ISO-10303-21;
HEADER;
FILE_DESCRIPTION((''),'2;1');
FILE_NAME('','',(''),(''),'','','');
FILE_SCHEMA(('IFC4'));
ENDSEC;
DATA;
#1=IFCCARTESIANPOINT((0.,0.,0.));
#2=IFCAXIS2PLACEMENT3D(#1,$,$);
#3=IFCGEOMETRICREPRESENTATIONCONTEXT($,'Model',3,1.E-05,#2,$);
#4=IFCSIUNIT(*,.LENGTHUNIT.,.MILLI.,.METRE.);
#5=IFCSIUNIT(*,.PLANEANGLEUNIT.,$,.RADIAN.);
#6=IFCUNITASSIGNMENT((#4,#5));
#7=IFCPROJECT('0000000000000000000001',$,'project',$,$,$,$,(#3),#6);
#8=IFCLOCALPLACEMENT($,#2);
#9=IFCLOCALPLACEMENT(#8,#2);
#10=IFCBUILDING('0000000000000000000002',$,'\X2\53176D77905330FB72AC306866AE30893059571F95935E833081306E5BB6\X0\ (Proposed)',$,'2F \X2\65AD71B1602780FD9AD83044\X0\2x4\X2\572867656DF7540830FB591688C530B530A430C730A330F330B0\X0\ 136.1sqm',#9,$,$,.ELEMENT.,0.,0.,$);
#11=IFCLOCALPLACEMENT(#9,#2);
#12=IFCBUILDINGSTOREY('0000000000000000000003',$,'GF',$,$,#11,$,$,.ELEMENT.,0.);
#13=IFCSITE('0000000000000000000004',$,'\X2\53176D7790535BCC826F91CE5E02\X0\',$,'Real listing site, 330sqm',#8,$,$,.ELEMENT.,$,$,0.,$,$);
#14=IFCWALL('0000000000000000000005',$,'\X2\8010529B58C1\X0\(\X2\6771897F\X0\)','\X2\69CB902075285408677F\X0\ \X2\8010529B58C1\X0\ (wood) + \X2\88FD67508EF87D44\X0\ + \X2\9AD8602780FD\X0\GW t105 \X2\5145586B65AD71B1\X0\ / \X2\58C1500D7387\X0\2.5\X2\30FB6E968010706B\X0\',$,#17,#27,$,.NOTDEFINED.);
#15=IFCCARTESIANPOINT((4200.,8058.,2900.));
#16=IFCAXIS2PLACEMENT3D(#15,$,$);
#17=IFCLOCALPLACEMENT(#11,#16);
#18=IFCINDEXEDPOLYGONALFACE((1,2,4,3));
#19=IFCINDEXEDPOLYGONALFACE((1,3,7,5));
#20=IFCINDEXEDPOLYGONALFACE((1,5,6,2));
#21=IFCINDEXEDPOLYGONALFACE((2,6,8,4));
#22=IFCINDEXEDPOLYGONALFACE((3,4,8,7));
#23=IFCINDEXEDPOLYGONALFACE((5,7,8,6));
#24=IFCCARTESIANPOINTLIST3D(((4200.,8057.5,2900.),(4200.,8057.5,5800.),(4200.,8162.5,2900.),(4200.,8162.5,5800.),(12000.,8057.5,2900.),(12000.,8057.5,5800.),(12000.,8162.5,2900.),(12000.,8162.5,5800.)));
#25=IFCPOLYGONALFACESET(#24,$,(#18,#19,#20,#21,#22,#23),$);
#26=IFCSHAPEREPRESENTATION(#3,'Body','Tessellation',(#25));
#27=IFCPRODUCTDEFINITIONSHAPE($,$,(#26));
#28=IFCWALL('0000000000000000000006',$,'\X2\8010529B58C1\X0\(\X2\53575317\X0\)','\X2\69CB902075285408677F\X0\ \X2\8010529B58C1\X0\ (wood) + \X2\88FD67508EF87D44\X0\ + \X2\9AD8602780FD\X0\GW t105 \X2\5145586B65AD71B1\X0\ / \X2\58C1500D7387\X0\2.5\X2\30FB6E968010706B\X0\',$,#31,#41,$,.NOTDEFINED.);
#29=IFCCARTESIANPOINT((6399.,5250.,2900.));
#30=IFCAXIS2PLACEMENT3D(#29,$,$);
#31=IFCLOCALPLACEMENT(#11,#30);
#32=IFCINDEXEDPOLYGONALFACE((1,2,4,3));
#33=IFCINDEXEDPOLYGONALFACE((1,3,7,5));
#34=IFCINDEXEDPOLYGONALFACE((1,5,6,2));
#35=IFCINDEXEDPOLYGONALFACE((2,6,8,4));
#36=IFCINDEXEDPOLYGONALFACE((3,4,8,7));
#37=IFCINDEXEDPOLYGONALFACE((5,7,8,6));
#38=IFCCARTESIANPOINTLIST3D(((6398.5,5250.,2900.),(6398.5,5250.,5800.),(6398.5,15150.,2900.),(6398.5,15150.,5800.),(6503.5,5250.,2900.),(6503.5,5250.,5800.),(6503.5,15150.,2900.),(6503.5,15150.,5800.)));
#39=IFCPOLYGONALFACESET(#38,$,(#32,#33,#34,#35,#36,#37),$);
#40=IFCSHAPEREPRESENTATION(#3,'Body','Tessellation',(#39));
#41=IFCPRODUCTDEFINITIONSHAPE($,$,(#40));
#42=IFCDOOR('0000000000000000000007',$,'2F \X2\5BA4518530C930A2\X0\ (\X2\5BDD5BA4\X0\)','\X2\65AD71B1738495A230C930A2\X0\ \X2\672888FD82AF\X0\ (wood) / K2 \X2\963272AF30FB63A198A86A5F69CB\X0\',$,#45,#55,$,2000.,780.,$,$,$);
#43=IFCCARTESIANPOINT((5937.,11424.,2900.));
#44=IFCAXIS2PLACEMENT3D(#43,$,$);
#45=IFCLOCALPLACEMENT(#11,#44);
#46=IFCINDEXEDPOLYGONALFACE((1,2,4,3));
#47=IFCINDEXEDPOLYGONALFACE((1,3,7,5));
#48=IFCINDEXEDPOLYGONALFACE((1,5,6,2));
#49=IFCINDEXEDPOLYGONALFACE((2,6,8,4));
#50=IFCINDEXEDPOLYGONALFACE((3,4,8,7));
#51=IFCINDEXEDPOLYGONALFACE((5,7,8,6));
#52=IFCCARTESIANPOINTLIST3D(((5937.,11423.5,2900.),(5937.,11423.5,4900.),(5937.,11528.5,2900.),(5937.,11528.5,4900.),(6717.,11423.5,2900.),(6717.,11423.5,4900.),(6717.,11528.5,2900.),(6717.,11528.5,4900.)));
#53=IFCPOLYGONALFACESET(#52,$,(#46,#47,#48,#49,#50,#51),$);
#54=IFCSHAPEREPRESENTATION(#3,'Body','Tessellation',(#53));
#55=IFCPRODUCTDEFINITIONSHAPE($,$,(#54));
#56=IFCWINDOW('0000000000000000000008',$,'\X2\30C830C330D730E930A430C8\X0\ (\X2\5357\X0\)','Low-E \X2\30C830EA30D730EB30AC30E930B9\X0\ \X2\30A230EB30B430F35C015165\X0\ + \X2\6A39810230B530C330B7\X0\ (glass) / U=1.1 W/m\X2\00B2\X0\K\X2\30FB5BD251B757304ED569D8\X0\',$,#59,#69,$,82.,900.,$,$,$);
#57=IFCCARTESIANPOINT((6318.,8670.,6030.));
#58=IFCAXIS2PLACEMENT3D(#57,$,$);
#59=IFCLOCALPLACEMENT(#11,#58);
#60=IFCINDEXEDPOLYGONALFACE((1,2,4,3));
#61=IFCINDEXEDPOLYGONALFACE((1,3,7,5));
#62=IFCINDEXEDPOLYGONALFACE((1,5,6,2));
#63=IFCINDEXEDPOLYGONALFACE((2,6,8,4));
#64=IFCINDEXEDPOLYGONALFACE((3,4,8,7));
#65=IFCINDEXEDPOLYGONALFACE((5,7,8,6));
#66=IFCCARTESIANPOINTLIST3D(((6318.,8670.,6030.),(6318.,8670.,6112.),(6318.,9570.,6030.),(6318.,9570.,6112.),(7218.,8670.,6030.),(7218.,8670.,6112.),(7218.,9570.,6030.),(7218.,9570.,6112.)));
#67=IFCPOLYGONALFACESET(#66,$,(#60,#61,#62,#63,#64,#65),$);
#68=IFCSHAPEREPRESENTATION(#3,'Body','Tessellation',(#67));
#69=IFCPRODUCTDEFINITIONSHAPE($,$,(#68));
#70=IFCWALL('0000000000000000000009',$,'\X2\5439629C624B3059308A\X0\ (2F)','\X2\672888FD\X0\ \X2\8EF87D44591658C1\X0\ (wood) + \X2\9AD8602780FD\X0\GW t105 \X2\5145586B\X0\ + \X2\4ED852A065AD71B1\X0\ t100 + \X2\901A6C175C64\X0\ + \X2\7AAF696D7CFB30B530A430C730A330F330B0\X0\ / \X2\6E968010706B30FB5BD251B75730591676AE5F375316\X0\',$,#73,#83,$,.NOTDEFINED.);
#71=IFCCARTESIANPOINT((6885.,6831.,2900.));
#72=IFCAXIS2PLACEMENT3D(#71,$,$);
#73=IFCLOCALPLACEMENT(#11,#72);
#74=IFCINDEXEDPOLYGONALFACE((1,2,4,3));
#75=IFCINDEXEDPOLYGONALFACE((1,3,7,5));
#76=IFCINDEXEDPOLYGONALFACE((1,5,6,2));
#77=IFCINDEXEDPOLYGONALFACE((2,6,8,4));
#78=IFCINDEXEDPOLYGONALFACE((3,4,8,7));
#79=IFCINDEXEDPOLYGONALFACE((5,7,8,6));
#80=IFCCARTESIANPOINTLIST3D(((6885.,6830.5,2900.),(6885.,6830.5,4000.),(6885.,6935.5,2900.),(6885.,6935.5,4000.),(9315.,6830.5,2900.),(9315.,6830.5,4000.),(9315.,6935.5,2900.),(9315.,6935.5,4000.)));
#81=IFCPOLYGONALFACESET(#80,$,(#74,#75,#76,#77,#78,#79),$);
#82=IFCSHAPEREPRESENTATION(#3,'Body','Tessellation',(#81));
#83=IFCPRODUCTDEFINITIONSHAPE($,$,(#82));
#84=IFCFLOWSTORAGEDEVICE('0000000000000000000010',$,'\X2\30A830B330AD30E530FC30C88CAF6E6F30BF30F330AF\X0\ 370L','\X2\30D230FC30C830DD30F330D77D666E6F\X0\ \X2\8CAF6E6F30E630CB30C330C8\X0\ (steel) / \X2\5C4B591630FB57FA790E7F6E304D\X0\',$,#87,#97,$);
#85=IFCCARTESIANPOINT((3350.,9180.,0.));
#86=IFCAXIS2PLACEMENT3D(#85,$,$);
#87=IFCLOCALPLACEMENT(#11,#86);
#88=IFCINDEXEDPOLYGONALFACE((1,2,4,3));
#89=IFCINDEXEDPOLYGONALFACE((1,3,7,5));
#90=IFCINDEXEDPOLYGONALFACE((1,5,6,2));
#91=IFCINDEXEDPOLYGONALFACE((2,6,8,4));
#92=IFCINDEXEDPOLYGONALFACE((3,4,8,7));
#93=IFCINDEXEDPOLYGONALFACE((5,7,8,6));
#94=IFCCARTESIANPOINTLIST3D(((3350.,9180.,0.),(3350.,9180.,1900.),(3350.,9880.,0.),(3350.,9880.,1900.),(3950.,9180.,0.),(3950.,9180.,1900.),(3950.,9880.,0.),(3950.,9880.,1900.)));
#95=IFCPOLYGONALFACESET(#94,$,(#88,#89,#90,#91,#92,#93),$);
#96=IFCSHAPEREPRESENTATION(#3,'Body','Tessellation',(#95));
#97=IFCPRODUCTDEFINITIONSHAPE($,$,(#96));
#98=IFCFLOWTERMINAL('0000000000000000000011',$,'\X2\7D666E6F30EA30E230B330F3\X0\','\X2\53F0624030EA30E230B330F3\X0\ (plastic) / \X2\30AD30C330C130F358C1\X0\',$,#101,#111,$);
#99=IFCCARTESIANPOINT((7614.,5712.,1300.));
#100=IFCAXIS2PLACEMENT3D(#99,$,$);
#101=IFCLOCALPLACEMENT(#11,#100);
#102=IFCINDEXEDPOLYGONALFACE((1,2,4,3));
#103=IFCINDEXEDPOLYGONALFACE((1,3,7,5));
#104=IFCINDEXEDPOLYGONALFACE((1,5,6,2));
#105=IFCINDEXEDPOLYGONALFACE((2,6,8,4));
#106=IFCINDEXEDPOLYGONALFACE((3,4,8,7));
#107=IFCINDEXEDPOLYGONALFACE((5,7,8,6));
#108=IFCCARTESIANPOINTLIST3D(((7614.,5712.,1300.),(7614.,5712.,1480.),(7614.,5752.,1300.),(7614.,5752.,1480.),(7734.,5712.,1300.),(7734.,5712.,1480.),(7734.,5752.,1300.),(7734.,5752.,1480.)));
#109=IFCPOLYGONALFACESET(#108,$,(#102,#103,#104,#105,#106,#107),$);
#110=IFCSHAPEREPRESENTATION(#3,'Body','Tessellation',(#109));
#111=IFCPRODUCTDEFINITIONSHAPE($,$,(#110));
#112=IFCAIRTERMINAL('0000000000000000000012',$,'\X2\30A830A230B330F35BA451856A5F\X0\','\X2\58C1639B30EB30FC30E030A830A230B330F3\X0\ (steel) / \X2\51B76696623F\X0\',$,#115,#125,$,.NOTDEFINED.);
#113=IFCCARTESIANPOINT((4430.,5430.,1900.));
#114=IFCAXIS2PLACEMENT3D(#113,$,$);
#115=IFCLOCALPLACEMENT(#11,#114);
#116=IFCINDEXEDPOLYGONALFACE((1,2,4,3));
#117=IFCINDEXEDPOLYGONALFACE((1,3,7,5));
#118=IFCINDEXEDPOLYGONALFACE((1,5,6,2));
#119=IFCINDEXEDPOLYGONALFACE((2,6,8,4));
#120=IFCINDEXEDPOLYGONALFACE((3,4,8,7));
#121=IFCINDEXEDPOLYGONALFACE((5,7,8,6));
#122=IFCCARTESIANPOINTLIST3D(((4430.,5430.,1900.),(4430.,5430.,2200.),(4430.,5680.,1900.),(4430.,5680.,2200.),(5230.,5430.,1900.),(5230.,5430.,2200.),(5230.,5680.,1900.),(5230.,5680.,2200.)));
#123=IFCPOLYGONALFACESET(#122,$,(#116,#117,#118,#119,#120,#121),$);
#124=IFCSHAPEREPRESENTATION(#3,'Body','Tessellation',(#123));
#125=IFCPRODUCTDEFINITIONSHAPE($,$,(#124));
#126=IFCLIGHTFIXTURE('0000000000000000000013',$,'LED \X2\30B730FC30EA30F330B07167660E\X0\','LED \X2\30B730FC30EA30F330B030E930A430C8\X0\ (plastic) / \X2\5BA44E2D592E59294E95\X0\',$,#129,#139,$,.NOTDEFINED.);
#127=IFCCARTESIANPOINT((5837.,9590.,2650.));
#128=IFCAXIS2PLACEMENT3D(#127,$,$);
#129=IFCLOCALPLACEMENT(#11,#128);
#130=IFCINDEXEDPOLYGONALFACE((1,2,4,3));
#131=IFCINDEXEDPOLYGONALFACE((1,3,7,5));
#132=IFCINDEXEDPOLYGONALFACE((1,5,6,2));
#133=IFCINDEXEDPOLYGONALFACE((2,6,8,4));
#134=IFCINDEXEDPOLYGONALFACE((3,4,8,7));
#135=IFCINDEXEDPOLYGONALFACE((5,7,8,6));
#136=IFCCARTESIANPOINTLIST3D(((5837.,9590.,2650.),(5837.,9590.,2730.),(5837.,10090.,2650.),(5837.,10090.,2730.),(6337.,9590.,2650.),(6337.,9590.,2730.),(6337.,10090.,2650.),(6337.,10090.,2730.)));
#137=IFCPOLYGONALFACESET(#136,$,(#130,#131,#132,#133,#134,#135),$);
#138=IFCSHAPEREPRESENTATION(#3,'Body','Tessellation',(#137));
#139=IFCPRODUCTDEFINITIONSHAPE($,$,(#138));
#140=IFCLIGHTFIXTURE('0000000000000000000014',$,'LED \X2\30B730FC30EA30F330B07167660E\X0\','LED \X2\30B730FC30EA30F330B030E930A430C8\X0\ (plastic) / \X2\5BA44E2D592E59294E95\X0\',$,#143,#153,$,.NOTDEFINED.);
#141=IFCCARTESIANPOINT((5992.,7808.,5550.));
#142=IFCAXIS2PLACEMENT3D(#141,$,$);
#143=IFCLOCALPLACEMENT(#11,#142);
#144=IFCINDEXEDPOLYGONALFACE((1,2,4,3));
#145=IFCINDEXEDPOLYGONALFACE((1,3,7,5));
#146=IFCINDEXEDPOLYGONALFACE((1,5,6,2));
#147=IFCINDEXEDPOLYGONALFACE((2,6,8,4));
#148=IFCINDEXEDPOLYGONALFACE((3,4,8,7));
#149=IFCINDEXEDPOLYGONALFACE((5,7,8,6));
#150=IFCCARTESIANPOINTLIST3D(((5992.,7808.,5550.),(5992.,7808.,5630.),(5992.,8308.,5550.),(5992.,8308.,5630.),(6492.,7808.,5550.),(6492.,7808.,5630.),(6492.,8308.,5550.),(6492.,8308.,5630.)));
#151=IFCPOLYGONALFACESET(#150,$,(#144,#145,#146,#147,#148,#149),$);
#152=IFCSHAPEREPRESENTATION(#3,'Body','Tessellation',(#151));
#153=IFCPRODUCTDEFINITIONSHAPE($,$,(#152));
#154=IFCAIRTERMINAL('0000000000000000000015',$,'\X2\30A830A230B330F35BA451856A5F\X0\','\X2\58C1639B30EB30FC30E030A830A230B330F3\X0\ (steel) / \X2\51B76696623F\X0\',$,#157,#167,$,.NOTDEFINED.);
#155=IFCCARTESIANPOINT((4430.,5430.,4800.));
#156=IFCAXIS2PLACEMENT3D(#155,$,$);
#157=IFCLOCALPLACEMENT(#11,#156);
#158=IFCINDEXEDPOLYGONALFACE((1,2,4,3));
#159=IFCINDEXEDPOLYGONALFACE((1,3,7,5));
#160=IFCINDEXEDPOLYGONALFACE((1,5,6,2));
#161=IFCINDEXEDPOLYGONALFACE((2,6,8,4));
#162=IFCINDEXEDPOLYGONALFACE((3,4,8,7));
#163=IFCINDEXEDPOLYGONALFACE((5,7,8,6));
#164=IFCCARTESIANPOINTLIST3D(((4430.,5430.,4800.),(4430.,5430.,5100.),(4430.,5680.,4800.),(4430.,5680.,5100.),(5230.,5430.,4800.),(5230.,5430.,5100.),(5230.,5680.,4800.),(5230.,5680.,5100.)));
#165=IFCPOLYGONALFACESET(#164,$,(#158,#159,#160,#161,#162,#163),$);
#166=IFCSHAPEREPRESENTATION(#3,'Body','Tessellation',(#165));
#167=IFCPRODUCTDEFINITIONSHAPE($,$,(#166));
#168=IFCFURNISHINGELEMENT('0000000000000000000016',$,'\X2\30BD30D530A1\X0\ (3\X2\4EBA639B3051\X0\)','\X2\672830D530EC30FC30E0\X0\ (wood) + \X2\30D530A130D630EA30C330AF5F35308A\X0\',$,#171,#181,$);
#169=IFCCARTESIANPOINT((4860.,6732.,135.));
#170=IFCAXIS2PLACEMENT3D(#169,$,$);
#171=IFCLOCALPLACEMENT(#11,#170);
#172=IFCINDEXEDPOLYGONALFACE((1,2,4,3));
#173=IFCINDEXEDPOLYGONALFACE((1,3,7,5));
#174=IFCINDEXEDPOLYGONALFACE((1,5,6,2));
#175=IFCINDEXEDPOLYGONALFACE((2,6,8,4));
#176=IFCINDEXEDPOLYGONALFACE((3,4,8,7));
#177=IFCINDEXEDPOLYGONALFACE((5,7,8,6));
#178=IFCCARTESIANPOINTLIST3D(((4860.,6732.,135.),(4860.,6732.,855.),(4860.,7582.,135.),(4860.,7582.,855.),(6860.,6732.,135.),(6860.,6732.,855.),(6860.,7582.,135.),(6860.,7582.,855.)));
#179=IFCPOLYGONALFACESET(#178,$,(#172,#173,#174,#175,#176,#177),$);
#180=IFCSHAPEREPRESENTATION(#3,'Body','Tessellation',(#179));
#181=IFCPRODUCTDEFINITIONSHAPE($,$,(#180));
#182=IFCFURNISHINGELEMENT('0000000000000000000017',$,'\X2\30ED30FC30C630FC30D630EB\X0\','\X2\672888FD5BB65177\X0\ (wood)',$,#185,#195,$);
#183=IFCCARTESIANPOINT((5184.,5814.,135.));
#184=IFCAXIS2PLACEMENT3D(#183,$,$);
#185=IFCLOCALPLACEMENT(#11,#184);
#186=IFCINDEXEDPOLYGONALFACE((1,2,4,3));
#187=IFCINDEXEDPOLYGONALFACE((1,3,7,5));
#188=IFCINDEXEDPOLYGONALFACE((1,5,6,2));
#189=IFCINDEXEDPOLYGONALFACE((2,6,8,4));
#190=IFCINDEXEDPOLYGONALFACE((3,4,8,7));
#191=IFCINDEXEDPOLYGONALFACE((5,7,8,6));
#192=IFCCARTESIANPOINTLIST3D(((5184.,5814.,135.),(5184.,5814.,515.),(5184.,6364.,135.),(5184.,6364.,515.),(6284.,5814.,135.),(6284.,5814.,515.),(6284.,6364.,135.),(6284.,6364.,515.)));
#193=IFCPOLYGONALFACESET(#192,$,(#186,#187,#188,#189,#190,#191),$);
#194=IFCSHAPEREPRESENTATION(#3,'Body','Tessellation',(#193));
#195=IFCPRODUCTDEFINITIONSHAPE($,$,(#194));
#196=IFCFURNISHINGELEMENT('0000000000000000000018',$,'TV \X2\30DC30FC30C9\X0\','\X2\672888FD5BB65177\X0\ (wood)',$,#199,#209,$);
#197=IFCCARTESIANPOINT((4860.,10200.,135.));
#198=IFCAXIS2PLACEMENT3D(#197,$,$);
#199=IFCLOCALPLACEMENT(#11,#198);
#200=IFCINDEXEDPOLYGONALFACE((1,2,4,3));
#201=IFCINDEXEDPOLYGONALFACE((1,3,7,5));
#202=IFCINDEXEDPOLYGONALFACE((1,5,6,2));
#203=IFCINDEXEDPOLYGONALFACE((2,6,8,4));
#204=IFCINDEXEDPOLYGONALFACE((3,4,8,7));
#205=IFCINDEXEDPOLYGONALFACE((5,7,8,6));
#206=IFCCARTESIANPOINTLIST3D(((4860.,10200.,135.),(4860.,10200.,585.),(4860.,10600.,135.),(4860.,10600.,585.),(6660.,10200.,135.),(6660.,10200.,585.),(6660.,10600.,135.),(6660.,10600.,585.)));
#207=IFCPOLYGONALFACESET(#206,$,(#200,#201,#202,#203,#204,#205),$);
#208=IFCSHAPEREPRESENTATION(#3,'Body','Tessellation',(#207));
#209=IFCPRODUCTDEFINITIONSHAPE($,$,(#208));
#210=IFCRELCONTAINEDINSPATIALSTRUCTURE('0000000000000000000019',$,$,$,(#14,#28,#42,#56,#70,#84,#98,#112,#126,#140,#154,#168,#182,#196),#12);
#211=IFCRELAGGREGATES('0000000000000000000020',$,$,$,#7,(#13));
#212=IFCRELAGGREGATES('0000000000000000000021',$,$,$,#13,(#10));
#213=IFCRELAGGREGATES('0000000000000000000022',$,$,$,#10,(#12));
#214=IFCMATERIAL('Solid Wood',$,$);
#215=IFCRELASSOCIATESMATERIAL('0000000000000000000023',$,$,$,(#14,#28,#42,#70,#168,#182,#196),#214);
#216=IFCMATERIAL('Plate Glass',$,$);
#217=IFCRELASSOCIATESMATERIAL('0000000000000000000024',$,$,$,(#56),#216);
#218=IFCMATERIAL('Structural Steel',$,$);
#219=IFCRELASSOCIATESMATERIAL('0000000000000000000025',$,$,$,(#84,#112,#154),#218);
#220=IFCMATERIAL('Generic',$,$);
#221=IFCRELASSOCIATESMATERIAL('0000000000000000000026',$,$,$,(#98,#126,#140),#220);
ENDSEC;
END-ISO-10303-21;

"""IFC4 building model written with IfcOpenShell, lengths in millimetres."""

from ifc_helpers import new_model, si_unit, frame, frame_2d, origin, place, context, project, spatial, rectangle, extrude, material, element, fill, save


model = new_model("IFC4")

# Units and contexts
model_context = context("Model", 3, precision=1e-05, world=origin())
ifc_project = project(units=[si_unit("LENGTHUNIT", "METRE", prefix="MILLI"), si_unit("PLANEANGLEUNIT", "RADIAN")], contexts=[model_context])

# Site, building, storey
site_placement = place(None, origin())
site = spatial("IfcSite", under=ifc_project, at=site_placement, Name="北海道富良野市", ObjectType="Real listing site, 330sqm", CompositionType="ELEMENT", RefElevation=0.0)
building_placement = place(site_placement, origin())
building = spatial("IfcBuilding", under=site, at=building_placement, Name="北海道・犬と暮らす土間広めの家 (Proposed)", ObjectType="2F 断熱性能高い2x4在来混合・外装サイディング 136.1sqm", CompositionType="ELEMENT", ElevationOfRefHeight=0.0, ElevationOfTerrain=0.0)
storey_placement = place(building_placement, origin())
storey = spatial("IfcBuildingStorey", under=building, at=storey_placement, Name="GF", CompositionType="ELEMENT", Elevation=0.0)

# Shared definitions
ifc_material_1 = material(Name="Solid Wood")

# Wall
wall_1_placement = place(storey_placement, frame((4200.0, 8058.0, 2900.0)))
element("IfcWall", 1, at=wall_1_placement, inside=storey, material=ifc_material_1, Name="耐力壁(東西)", Description="構造用合板 耐力壁 (wood) + 製材軸組 + 高性能GW t105 充填断熱 / 壁倍率2.5・準耐火", PredefinedType="NOTDEFINED", context=model_context, shape_type="SweptSolid", body=[
    extrude(rectangle(XDim=7800.0, YDim=105.0, at=frame_2d((3900.0, 52.0))), frame((4200.0, 8058.0, 2900.0)), (0.0, 0.0, 1.0), 2900.0),
])

# Wall, opening, door
wall_2_placement = place(storey_placement, frame((6399.0, 5250.0, 2900.0)))
wall_2 = element("IfcWall", 2, at=wall_2_placement, inside=storey, material=ifc_material_1, Name="耐力壁(南北)", Description="構造用合板 耐力壁 (wood) + 製材軸組 + 高性能GW t105 充填断熱 / 壁倍率2.5・準耐火", PredefinedType="NOTDEFINED", context=model_context, shape_type="SweptSolid", body=[
    extrude(rectangle(XDim=105.0, YDim=9900.0, at=frame_2d((52.0, 4950.0))), frame((6399.0, 5250.0, 2900.0)), (0.0, 0.0, 1.0), 2900.0),
])
opening_placement = place(storey_placement, frame((5937.0, 11424.0, 2900.0)))
opening = element("IfcOpeningElement", 3, at=opening_placement, cuts=wall_2, PredefinedType="NOTDEFINED", context=model_context, shape_type="SweptSolid", body=[
    extrude(rectangle(XDim=780.0, YDim=105.0, at=frame_2d((390.0, 52.0))), frame((5937.0, 11424.0, 2900.0)), (0.0, 0.0, 1.0), 2000.0),
])
door_placement = place(storey_placement, frame((5937.0, 11424.0, 2900.0)))
door = element("IfcDoor", 4, at=door_placement, inside=storey, material=ifc_material_1, Name="2F 室内ドア (寝室)", Description="断熱玄関ドア 木製芯 (wood) / K2 防犯・採風機構", OverallHeight=2000.0, OverallWidth=780.0, context=model_context, shape_type="SweptSolid", body=[
    extrude(rectangle(XDim=780.0, YDim=105.0, at=frame_2d((390.0, 52.0))), frame((5937.0, 11424.0, 2900.0)), (0.0, 0.0, 1.0), 2000.0),
])
fill(opening, door)

# Window
ifc_material_2 = material(Name="Plate Glass")
window_placement = place(storey_placement, frame((6318.0, 8670.0, 6030.0)))
element("IfcWindow", 5, at=window_placement, inside=storey, material=ifc_material_2, Name="トップライト (南)", Description="Low-E トリプルガラス アルゴン封入 + 樹脂サッシ (glass) / U=1.1 W/m²K・寒冷地仕様", OverallHeight=82.0, OverallWidth=900.0, context=model_context, shape_type="SweptSolid", body=[
    extrude(rectangle(XDim=900.0, YDim=900.0, at=frame_2d((450.0, 450.0))), frame((6318.0, 8670.0, 6030.0)), (0.0, 0.0, 1.0), 82.0),
])

# Wall
wall_3_placement = place(storey_placement, frame((6885.0, 6831.0, 2900.0)))
element("IfcWall", 6, at=wall_3_placement, inside=storey, material=ifc_material_1, Name="吹抜手すり (2F)", Description="木製 軸組外壁 (wood) + 高性能GW t105 充填 + 付加断熱 t100 + 通気層 + 窯業系サイディング / 準耐火・寒冷地外皮強化", PredefinedType="NOTDEFINED", context=model_context, shape_type="SweptSolid", body=[
    extrude(rectangle(XDim=2430.0, YDim=105.0, at=frame_2d((1215.0, 52.0))), frame((6885.0, 6831.0, 2900.0)), (0.0, 0.0, 1.0), 1100.0),
])

# Flow storage device
ifc_material_3 = material(Name="Structural Steel")
flow_storage_device_placement = place(storey_placement, frame((3350.0, 9180.0, 0.0)))
element("IfcFlowStorageDevice", 7, at=flow_storage_device_placement, inside=storey, material=ifc_material_3, Name="エコキュート貯湯タンク 370L", Description="ヒートポンプ給湯 貯湯ユニット (steel) / 屋外・基礎置き", context=model_context, shape_type="SweptSolid", body=[
    extrude(rectangle(XDim=600.0, YDim=700.0, at=frame_2d((300.0, 350.0))), frame((3350.0, 9180.0, 0.0)), (0.0, 0.0, 1.0), 1900.0),
])

# Flow terminal
ifc_material_4 = material(Name="Generic")
flow_terminal_placement = place(storey_placement, frame((7614.0, 5712.0, 1300.0)))
element("IfcFlowTerminal", 8, at=flow_terminal_placement, inside=storey, material=ifc_material_4, Name="給湯リモコン", Description="台所リモコン (plastic) / キッチン壁", context=model_context, shape_type="SweptSolid", body=[
    extrude(rectangle(XDim=120.0, YDim=40.0, at=frame_2d((60.0, 20.0))), frame((7614.0, 5712.0, 1300.0)), (0.0, 0.0, 1.0), 180.0),
])

# Air terminal
air_terminal_1_placement = place(storey_placement, frame((4430.0, 5430.0, 1900.0)))
element("IfcAirTerminal", 9, at=air_terminal_1_placement, inside=storey, material=ifc_material_3, Name="エアコン室内機", Description="壁掛ルームエアコン (steel) / 冷暖房", PredefinedType="NOTDEFINED", context=model_context, shape_type="SweptSolid", body=[
    extrude(rectangle(XDim=800.0, YDim=250.0, at=frame_2d((400.0, 125.0))), frame((4430.0, 5430.0, 1900.0)), (0.0, 0.0, 1.0), 300.0),
])

# Light fixtures
light_fixture_1_placement = place(storey_placement, frame((5837.0, 9590.0, 2650.0)))
element("IfcLightFixture", 10, at=light_fixture_1_placement, inside=storey, material=ifc_material_4, Name="LED シーリング照明", Description="LED シーリングライト (plastic) / 室中央天井", PredefinedType="NOTDEFINED", context=model_context, shape_type="SweptSolid", body=[
    extrude(rectangle(XDim=500.0, YDim=500.0, at=frame_2d((250.0, 250.0))), frame((5837.0, 9590.0, 2650.0)), (0.0, 0.0, 1.0), 80.0),
])
light_fixture_2_placement = place(storey_placement, frame((5992.0, 7808.0, 5550.0)))
element("IfcLightFixture", 11, at=light_fixture_2_placement, inside=storey, material=ifc_material_4, Name="LED シーリング照明", Description="LED シーリングライト (plastic) / 室中央天井", PredefinedType="NOTDEFINED", context=model_context, shape_type="SweptSolid", body=[
    extrude(rectangle(XDim=500.0, YDim=500.0, at=frame_2d((250.0, 250.0))), frame((5992.0, 7808.0, 5550.0)), (0.0, 0.0, 1.0), 80.0),
])

# Air terminal
air_terminal_2_placement = place(storey_placement, frame((4430.0, 5430.0, 4800.0)))
element("IfcAirTerminal", 12, at=air_terminal_2_placement, inside=storey, material=ifc_material_3, Name="エアコン室内機", Description="壁掛ルームエアコン (steel) / 冷暖房", PredefinedType="NOTDEFINED", context=model_context, shape_type="SweptSolid", body=[
    extrude(rectangle(XDim=800.0, YDim=250.0, at=frame_2d((400.0, 125.0))), frame((4430.0, 5430.0, 4800.0)), (0.0, 0.0, 1.0), 300.0),
])

# Furnishing elements
furnishing_1_placement = place(storey_placement, frame((4860.0, 6732.0, 135.0)))
element("IfcFurnishingElement", 13, at=furnishing_1_placement, inside=storey, material=ifc_material_1, Name="ソファ (3人掛け)", Description="木フレーム (wood) + ファブリック張り", context=model_context, shape_type="SweptSolid", body=[
    extrude(rectangle(XDim=2000.0, YDim=850.0, at=frame_2d((1000.0, 425.0))), frame((4860.0, 6732.0, 135.0)), (0.0, 0.0, 1.0), 720.0),
])
furnishing_2_placement = place(storey_placement, frame((5184.0, 5814.0, 135.0)))
element("IfcFurnishingElement", 14, at=furnishing_2_placement, inside=storey, material=ifc_material_1, Name="ローテーブル", Description="木製家具 (wood)", context=model_context, shape_type="SweptSolid", body=[
    extrude(rectangle(XDim=1100.0, YDim=550.0, at=frame_2d((550.0, 275.0))), frame((5184.0, 5814.0, 135.0)), (0.0, 0.0, 1.0), 380.0),
])
furnishing_3_placement = place(storey_placement, frame((4860.0, 10200.0, 135.0)))
element("IfcFurnishingElement", 15, at=furnishing_3_placement, inside=storey, material=ifc_material_1, Name="TV ボード", Description="木製家具 (wood)", context=model_context, shape_type="SweptSolid", body=[
    extrude(rectangle(XDim=1800.0, YDim=400.0, at=frame_2d((900.0, 200.0))), frame((4860.0, 10200.0, 135.0)), (0.0, 0.0, 1.0), 450.0),
])

save(model, "model.ifc")
